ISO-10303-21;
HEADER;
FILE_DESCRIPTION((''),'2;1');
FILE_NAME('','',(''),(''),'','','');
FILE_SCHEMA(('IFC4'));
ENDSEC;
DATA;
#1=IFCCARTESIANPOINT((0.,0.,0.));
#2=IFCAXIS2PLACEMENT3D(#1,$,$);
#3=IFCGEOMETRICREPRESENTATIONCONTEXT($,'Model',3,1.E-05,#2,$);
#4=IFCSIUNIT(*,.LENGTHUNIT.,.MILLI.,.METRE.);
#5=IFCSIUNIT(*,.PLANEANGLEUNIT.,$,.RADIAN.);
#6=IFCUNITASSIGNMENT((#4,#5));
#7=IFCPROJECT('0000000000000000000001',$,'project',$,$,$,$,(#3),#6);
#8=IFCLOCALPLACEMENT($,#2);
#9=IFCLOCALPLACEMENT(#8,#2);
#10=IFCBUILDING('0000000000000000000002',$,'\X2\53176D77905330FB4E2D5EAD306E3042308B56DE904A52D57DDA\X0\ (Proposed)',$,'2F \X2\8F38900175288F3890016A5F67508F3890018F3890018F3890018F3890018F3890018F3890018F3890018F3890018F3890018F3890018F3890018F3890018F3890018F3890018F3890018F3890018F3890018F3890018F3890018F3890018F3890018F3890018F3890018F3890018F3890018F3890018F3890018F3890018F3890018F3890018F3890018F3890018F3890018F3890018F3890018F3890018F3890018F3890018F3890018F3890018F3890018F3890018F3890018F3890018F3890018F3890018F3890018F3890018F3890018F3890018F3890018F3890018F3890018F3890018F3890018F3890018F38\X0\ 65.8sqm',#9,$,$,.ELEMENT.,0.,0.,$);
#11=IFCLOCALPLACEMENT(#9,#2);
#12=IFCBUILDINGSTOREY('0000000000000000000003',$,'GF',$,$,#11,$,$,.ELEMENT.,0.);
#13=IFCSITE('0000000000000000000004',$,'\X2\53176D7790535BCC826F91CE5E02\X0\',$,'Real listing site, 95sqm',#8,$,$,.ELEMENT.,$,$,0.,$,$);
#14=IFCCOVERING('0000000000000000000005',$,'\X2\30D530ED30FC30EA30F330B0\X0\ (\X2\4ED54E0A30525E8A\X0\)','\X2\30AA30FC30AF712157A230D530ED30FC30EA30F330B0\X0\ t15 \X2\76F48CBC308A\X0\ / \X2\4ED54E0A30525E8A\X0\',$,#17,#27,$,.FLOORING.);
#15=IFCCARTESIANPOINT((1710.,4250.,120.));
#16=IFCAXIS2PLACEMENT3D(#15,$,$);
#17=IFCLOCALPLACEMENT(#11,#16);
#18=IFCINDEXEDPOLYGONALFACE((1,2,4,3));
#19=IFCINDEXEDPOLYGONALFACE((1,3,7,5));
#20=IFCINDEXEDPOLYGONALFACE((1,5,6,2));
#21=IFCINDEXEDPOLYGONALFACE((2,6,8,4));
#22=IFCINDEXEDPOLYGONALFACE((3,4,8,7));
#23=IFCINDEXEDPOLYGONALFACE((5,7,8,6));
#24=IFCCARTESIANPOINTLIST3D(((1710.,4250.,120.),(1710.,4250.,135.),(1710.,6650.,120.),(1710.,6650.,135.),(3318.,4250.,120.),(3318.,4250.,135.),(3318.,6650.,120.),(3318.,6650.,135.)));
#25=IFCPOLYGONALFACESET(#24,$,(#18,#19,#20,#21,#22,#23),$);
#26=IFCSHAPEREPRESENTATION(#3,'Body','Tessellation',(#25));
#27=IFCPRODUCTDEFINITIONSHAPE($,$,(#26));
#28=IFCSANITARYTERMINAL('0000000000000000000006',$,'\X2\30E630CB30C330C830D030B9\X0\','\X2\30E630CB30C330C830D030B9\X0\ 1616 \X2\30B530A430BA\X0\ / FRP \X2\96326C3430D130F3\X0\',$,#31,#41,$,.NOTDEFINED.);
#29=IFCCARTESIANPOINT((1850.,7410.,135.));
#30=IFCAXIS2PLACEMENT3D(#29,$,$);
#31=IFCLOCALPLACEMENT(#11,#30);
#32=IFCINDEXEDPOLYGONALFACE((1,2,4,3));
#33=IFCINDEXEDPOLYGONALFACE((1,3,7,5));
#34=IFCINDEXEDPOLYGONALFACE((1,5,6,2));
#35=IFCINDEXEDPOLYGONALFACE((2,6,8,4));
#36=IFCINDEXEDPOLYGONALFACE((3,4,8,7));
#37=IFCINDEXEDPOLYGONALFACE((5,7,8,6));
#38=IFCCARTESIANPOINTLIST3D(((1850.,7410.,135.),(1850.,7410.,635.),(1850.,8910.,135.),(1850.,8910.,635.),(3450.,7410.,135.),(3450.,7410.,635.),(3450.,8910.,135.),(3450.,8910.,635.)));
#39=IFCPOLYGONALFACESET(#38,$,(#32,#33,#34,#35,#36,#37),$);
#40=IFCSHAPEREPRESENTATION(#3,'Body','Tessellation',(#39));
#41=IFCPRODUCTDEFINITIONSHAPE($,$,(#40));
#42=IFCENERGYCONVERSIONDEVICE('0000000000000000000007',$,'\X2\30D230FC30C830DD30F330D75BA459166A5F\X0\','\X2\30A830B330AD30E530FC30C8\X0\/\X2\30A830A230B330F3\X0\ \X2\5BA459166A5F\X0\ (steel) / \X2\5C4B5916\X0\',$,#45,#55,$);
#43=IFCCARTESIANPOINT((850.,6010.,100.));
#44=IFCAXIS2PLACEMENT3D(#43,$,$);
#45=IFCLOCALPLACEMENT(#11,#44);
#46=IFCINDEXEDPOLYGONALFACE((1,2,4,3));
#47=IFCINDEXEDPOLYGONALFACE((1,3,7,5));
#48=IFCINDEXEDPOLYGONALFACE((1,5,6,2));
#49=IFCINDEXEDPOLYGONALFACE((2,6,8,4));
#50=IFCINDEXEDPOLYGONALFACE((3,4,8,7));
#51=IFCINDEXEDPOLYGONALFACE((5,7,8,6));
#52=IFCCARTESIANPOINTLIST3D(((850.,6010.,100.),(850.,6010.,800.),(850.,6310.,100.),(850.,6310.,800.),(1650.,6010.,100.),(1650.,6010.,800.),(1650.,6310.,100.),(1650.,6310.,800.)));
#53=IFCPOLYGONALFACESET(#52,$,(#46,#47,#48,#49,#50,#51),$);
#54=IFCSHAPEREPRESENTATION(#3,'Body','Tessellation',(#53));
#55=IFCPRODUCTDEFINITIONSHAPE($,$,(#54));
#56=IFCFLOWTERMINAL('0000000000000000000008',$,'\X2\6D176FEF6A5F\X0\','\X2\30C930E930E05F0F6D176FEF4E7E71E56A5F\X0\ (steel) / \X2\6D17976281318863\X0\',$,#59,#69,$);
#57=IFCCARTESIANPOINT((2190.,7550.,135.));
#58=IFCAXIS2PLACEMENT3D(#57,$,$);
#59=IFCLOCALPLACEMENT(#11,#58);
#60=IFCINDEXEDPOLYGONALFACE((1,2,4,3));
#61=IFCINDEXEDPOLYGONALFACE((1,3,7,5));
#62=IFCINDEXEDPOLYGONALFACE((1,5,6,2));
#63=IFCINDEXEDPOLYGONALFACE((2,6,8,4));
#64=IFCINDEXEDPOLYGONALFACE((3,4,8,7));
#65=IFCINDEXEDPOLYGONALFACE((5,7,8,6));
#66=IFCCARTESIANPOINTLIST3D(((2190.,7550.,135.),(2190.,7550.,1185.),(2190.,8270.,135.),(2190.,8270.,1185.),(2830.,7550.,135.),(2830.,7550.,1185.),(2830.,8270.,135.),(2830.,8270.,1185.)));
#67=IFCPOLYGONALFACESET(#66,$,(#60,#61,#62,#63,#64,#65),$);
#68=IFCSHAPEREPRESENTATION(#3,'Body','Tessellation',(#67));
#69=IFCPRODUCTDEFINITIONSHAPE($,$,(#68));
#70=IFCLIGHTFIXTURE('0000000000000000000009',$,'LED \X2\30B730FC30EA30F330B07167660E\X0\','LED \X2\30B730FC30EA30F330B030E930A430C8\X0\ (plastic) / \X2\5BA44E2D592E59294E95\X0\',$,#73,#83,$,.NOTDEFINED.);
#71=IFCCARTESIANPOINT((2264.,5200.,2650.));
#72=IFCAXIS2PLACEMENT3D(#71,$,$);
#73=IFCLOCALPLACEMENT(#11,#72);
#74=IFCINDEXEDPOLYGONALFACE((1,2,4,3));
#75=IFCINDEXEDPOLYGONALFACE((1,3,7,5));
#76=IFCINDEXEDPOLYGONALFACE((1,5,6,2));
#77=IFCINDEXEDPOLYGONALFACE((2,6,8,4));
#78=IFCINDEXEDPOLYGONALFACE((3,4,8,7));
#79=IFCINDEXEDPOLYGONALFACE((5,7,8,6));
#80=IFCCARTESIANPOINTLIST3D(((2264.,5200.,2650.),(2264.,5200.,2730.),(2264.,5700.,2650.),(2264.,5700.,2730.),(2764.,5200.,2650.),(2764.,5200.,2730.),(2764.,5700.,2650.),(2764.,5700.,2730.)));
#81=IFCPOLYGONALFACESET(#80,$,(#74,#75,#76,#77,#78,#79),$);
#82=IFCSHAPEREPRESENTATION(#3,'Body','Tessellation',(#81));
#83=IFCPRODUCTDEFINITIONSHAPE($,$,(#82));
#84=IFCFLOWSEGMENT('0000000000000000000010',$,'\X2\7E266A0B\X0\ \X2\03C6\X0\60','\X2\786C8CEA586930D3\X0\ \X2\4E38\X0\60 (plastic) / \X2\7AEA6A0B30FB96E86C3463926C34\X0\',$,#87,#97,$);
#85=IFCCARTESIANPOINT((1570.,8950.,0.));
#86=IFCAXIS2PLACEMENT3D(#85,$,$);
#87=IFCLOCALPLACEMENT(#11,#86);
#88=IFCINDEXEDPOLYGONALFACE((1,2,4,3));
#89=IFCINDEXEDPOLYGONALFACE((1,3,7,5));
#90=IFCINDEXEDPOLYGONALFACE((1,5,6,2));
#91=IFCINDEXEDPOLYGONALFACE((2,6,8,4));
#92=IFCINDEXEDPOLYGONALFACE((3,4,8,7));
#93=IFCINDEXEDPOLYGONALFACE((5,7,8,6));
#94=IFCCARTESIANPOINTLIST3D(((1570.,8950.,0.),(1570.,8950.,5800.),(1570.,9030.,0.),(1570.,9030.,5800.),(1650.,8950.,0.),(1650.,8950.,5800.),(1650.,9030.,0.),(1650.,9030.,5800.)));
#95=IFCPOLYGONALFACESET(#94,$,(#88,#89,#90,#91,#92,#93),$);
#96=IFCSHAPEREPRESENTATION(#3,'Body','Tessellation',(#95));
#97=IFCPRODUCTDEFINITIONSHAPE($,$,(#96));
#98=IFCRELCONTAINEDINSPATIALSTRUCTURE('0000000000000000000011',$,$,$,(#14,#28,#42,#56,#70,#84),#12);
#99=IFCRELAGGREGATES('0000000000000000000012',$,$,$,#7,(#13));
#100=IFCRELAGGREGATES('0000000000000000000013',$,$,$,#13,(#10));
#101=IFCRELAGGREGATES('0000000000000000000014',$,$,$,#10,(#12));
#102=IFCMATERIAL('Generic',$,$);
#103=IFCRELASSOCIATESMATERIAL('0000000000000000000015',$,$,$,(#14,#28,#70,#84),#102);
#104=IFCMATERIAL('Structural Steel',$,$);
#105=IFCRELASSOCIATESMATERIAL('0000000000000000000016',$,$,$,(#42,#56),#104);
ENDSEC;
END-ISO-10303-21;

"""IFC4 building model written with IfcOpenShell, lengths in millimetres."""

from ifc_helpers import new_model, si_unit, frame, frame_2d, origin, place, context, project, spatial, rectangle, extrude, material, element, save


model = new_model("IFC4")

# Units and contexts
model_context = context("Model", 3, precision=1e-05, world=origin())
ifc_project = project(units=[si_unit("LENGTHUNIT", "METRE", prefix="MILLI"), si_unit("PLANEANGLEUNIT", "RADIAN")], contexts=[model_context])

# Site, building, storey
site_placement = place(None, origin())
site = spatial("IfcSite", under=ifc_project, at=site_placement, Name="北海道富良野市", ObjectType="Real listing site, 95sqm", CompositionType="ELEMENT", RefElevation=0.0)
building_placement = place(site_placement, origin())
building = spatial("IfcBuilding", under=site, at=building_placement, Name="北海道・中庭のある回遊動線 (Proposed)", ObjectType="2F 輸送用輸送機材輸送輸送輸送輸送輸送輸送輸送輸送輸送輸送輸送輸送輸送輸送輸送輸送輸送輸送輸送輸送輸送輸送輸送輸送輸送輸送輸送輸送輸送輸送輸送輸送輸送輸送輸送輸送輸送輸送輸送輸送輸送輸送輸送輸送輸送輸送輸送輸送輸送輸送輸送輸送輸送輸送輸送輸送輸 65.8sqm", CompositionType="ELEMENT", ElevationOfRefHeight=0.0, ElevationOfTerrain=0.0)
storey_placement = place(building_placement, origin())
storey = spatial("IfcBuildingStorey", under=building, at=storey_placement, Name="GF", CompositionType="ELEMENT", Elevation=0.0)

# Covering
ifc_material_1 = material(Name="Generic")
covering_1_placement = place(storey_placement, frame((1710.0, 4250.0, 120.0)))
element("IfcCovering", 1, at=covering_1_placement, inside=storey, material=ifc_material_1, Name="フローリング (仕上げ床)", Description="オーク無垢フローリング t15 直貼り / 仕上げ床", PredefinedType="FLOORING", context=model_context, shape_type="SweptSolid", body=[
    extrude(rectangle(XDim=1608.0, YDim=2400.0, at=frame_2d((804.0, 1200.0))), frame((1710.0, 4250.0, 120.0)), (0.0, 0.0, 1.0), 15.0),
])

# Sanitary terminal
sanitary_terminal_placement = place(storey_placement, frame((1850.0, 7410.0, 135.0)))
element("IfcSanitaryTerminal", 2, at=sanitary_terminal_placement, inside=storey, material=ifc_material_1, Name="ユニットバス", Description="ユニットバス 1616 サイズ / FRP 防水パン", PredefinedType="NOTDEFINED", context=model_context, shape_type="SweptSolid", body=[
    extrude(rectangle(XDim=1600.0, YDim=1500.0, at=frame_2d((800.0, 750.0))), frame((1850.0, 7410.0, 135.0)), (0.0, 0.0, 1.0), 500.0),
])

# Shared definitions
ifc_material_2 = material(Name="Structural Steel")

# Energy conversion device
energy_conversion_device_placement = place(storey_placement, frame((850.0, 6010.0, 100.0)))
element("IfcEnergyConversionDevice", 3, at=energy_conversion_device_placement, inside=storey, material=ifc_material_2, Name="ヒートポンプ室外機", Description="エコキュート/エアコン 室外機 (steel) / 屋外", context=model_context, shape_type="SweptSolid", body=[
    extrude(rectangle(XDim=800.0, YDim=300.0, at=frame_2d((400.0, 150.0))), frame((850.0, 6010.0, 100.0)), (0.0, 0.0, 1.0), 700.0),
])

# Flow terminal
flow_terminal_placement = place(storey_placement, frame((2190.0, 7550.0, 135.0)))
element("IfcFlowTerminal", 4, at=flow_terminal_placement, inside=storey, material=ifc_material_2, Name="洗濯機", Description="ドラム式洗濯乾燥機 (steel) / 洗面脱衣", context=model_context, shape_type="SweptSolid", body=[
    extrude(rectangle(XDim=640.0, YDim=720.0, at=frame_2d((320.0, 360.0))), frame((2190.0, 7550.0, 135.0)), (0.0, 0.0, 1.0), 1050.0),
])

# Light fixture
light_fixture_placement = place(storey_placement, frame((2264.0, 5200.0, 2650.0)))
element("IfcLightFixture", 5, at=light_fixture_placement, inside=storey, material=ifc_material_1, Name="LED シーリング照明", Description="LED シーリングライト (plastic) / 室中央天井", PredefinedType="NOTDEFINED", context=model_context, shape_type="SweptSolid", body=[
    extrude(rectangle(XDim=500.0, YDim=500.0, at=frame_2d((250.0, 250.0))), frame((2264.0, 5200.0, 2650.0)), (0.0, 0.0, 1.0), 80.0),
])

# Flow segment
flow_segment_placement = place(storey_placement, frame((1570.0, 8950.0, 0.0)))
element("IfcFlowSegment", 6, at=flow_segment_placement, inside=storey, material=ifc_material_1, Name="縦樋 φ60", Description="硬質塩ビ 丸60 (plastic) / 竪樋・雨水排水", context=model_context, shape_type="SweptSolid", body=[
    extrude(rectangle(XDim=80.0, YDim=80.0, at=frame_2d((40.0, 40.0))), frame((1570.0, 8950.0, 0.0)), (0.0, 0.0, 1.0), 5800.0),
])

save(model, "model.ifc")
